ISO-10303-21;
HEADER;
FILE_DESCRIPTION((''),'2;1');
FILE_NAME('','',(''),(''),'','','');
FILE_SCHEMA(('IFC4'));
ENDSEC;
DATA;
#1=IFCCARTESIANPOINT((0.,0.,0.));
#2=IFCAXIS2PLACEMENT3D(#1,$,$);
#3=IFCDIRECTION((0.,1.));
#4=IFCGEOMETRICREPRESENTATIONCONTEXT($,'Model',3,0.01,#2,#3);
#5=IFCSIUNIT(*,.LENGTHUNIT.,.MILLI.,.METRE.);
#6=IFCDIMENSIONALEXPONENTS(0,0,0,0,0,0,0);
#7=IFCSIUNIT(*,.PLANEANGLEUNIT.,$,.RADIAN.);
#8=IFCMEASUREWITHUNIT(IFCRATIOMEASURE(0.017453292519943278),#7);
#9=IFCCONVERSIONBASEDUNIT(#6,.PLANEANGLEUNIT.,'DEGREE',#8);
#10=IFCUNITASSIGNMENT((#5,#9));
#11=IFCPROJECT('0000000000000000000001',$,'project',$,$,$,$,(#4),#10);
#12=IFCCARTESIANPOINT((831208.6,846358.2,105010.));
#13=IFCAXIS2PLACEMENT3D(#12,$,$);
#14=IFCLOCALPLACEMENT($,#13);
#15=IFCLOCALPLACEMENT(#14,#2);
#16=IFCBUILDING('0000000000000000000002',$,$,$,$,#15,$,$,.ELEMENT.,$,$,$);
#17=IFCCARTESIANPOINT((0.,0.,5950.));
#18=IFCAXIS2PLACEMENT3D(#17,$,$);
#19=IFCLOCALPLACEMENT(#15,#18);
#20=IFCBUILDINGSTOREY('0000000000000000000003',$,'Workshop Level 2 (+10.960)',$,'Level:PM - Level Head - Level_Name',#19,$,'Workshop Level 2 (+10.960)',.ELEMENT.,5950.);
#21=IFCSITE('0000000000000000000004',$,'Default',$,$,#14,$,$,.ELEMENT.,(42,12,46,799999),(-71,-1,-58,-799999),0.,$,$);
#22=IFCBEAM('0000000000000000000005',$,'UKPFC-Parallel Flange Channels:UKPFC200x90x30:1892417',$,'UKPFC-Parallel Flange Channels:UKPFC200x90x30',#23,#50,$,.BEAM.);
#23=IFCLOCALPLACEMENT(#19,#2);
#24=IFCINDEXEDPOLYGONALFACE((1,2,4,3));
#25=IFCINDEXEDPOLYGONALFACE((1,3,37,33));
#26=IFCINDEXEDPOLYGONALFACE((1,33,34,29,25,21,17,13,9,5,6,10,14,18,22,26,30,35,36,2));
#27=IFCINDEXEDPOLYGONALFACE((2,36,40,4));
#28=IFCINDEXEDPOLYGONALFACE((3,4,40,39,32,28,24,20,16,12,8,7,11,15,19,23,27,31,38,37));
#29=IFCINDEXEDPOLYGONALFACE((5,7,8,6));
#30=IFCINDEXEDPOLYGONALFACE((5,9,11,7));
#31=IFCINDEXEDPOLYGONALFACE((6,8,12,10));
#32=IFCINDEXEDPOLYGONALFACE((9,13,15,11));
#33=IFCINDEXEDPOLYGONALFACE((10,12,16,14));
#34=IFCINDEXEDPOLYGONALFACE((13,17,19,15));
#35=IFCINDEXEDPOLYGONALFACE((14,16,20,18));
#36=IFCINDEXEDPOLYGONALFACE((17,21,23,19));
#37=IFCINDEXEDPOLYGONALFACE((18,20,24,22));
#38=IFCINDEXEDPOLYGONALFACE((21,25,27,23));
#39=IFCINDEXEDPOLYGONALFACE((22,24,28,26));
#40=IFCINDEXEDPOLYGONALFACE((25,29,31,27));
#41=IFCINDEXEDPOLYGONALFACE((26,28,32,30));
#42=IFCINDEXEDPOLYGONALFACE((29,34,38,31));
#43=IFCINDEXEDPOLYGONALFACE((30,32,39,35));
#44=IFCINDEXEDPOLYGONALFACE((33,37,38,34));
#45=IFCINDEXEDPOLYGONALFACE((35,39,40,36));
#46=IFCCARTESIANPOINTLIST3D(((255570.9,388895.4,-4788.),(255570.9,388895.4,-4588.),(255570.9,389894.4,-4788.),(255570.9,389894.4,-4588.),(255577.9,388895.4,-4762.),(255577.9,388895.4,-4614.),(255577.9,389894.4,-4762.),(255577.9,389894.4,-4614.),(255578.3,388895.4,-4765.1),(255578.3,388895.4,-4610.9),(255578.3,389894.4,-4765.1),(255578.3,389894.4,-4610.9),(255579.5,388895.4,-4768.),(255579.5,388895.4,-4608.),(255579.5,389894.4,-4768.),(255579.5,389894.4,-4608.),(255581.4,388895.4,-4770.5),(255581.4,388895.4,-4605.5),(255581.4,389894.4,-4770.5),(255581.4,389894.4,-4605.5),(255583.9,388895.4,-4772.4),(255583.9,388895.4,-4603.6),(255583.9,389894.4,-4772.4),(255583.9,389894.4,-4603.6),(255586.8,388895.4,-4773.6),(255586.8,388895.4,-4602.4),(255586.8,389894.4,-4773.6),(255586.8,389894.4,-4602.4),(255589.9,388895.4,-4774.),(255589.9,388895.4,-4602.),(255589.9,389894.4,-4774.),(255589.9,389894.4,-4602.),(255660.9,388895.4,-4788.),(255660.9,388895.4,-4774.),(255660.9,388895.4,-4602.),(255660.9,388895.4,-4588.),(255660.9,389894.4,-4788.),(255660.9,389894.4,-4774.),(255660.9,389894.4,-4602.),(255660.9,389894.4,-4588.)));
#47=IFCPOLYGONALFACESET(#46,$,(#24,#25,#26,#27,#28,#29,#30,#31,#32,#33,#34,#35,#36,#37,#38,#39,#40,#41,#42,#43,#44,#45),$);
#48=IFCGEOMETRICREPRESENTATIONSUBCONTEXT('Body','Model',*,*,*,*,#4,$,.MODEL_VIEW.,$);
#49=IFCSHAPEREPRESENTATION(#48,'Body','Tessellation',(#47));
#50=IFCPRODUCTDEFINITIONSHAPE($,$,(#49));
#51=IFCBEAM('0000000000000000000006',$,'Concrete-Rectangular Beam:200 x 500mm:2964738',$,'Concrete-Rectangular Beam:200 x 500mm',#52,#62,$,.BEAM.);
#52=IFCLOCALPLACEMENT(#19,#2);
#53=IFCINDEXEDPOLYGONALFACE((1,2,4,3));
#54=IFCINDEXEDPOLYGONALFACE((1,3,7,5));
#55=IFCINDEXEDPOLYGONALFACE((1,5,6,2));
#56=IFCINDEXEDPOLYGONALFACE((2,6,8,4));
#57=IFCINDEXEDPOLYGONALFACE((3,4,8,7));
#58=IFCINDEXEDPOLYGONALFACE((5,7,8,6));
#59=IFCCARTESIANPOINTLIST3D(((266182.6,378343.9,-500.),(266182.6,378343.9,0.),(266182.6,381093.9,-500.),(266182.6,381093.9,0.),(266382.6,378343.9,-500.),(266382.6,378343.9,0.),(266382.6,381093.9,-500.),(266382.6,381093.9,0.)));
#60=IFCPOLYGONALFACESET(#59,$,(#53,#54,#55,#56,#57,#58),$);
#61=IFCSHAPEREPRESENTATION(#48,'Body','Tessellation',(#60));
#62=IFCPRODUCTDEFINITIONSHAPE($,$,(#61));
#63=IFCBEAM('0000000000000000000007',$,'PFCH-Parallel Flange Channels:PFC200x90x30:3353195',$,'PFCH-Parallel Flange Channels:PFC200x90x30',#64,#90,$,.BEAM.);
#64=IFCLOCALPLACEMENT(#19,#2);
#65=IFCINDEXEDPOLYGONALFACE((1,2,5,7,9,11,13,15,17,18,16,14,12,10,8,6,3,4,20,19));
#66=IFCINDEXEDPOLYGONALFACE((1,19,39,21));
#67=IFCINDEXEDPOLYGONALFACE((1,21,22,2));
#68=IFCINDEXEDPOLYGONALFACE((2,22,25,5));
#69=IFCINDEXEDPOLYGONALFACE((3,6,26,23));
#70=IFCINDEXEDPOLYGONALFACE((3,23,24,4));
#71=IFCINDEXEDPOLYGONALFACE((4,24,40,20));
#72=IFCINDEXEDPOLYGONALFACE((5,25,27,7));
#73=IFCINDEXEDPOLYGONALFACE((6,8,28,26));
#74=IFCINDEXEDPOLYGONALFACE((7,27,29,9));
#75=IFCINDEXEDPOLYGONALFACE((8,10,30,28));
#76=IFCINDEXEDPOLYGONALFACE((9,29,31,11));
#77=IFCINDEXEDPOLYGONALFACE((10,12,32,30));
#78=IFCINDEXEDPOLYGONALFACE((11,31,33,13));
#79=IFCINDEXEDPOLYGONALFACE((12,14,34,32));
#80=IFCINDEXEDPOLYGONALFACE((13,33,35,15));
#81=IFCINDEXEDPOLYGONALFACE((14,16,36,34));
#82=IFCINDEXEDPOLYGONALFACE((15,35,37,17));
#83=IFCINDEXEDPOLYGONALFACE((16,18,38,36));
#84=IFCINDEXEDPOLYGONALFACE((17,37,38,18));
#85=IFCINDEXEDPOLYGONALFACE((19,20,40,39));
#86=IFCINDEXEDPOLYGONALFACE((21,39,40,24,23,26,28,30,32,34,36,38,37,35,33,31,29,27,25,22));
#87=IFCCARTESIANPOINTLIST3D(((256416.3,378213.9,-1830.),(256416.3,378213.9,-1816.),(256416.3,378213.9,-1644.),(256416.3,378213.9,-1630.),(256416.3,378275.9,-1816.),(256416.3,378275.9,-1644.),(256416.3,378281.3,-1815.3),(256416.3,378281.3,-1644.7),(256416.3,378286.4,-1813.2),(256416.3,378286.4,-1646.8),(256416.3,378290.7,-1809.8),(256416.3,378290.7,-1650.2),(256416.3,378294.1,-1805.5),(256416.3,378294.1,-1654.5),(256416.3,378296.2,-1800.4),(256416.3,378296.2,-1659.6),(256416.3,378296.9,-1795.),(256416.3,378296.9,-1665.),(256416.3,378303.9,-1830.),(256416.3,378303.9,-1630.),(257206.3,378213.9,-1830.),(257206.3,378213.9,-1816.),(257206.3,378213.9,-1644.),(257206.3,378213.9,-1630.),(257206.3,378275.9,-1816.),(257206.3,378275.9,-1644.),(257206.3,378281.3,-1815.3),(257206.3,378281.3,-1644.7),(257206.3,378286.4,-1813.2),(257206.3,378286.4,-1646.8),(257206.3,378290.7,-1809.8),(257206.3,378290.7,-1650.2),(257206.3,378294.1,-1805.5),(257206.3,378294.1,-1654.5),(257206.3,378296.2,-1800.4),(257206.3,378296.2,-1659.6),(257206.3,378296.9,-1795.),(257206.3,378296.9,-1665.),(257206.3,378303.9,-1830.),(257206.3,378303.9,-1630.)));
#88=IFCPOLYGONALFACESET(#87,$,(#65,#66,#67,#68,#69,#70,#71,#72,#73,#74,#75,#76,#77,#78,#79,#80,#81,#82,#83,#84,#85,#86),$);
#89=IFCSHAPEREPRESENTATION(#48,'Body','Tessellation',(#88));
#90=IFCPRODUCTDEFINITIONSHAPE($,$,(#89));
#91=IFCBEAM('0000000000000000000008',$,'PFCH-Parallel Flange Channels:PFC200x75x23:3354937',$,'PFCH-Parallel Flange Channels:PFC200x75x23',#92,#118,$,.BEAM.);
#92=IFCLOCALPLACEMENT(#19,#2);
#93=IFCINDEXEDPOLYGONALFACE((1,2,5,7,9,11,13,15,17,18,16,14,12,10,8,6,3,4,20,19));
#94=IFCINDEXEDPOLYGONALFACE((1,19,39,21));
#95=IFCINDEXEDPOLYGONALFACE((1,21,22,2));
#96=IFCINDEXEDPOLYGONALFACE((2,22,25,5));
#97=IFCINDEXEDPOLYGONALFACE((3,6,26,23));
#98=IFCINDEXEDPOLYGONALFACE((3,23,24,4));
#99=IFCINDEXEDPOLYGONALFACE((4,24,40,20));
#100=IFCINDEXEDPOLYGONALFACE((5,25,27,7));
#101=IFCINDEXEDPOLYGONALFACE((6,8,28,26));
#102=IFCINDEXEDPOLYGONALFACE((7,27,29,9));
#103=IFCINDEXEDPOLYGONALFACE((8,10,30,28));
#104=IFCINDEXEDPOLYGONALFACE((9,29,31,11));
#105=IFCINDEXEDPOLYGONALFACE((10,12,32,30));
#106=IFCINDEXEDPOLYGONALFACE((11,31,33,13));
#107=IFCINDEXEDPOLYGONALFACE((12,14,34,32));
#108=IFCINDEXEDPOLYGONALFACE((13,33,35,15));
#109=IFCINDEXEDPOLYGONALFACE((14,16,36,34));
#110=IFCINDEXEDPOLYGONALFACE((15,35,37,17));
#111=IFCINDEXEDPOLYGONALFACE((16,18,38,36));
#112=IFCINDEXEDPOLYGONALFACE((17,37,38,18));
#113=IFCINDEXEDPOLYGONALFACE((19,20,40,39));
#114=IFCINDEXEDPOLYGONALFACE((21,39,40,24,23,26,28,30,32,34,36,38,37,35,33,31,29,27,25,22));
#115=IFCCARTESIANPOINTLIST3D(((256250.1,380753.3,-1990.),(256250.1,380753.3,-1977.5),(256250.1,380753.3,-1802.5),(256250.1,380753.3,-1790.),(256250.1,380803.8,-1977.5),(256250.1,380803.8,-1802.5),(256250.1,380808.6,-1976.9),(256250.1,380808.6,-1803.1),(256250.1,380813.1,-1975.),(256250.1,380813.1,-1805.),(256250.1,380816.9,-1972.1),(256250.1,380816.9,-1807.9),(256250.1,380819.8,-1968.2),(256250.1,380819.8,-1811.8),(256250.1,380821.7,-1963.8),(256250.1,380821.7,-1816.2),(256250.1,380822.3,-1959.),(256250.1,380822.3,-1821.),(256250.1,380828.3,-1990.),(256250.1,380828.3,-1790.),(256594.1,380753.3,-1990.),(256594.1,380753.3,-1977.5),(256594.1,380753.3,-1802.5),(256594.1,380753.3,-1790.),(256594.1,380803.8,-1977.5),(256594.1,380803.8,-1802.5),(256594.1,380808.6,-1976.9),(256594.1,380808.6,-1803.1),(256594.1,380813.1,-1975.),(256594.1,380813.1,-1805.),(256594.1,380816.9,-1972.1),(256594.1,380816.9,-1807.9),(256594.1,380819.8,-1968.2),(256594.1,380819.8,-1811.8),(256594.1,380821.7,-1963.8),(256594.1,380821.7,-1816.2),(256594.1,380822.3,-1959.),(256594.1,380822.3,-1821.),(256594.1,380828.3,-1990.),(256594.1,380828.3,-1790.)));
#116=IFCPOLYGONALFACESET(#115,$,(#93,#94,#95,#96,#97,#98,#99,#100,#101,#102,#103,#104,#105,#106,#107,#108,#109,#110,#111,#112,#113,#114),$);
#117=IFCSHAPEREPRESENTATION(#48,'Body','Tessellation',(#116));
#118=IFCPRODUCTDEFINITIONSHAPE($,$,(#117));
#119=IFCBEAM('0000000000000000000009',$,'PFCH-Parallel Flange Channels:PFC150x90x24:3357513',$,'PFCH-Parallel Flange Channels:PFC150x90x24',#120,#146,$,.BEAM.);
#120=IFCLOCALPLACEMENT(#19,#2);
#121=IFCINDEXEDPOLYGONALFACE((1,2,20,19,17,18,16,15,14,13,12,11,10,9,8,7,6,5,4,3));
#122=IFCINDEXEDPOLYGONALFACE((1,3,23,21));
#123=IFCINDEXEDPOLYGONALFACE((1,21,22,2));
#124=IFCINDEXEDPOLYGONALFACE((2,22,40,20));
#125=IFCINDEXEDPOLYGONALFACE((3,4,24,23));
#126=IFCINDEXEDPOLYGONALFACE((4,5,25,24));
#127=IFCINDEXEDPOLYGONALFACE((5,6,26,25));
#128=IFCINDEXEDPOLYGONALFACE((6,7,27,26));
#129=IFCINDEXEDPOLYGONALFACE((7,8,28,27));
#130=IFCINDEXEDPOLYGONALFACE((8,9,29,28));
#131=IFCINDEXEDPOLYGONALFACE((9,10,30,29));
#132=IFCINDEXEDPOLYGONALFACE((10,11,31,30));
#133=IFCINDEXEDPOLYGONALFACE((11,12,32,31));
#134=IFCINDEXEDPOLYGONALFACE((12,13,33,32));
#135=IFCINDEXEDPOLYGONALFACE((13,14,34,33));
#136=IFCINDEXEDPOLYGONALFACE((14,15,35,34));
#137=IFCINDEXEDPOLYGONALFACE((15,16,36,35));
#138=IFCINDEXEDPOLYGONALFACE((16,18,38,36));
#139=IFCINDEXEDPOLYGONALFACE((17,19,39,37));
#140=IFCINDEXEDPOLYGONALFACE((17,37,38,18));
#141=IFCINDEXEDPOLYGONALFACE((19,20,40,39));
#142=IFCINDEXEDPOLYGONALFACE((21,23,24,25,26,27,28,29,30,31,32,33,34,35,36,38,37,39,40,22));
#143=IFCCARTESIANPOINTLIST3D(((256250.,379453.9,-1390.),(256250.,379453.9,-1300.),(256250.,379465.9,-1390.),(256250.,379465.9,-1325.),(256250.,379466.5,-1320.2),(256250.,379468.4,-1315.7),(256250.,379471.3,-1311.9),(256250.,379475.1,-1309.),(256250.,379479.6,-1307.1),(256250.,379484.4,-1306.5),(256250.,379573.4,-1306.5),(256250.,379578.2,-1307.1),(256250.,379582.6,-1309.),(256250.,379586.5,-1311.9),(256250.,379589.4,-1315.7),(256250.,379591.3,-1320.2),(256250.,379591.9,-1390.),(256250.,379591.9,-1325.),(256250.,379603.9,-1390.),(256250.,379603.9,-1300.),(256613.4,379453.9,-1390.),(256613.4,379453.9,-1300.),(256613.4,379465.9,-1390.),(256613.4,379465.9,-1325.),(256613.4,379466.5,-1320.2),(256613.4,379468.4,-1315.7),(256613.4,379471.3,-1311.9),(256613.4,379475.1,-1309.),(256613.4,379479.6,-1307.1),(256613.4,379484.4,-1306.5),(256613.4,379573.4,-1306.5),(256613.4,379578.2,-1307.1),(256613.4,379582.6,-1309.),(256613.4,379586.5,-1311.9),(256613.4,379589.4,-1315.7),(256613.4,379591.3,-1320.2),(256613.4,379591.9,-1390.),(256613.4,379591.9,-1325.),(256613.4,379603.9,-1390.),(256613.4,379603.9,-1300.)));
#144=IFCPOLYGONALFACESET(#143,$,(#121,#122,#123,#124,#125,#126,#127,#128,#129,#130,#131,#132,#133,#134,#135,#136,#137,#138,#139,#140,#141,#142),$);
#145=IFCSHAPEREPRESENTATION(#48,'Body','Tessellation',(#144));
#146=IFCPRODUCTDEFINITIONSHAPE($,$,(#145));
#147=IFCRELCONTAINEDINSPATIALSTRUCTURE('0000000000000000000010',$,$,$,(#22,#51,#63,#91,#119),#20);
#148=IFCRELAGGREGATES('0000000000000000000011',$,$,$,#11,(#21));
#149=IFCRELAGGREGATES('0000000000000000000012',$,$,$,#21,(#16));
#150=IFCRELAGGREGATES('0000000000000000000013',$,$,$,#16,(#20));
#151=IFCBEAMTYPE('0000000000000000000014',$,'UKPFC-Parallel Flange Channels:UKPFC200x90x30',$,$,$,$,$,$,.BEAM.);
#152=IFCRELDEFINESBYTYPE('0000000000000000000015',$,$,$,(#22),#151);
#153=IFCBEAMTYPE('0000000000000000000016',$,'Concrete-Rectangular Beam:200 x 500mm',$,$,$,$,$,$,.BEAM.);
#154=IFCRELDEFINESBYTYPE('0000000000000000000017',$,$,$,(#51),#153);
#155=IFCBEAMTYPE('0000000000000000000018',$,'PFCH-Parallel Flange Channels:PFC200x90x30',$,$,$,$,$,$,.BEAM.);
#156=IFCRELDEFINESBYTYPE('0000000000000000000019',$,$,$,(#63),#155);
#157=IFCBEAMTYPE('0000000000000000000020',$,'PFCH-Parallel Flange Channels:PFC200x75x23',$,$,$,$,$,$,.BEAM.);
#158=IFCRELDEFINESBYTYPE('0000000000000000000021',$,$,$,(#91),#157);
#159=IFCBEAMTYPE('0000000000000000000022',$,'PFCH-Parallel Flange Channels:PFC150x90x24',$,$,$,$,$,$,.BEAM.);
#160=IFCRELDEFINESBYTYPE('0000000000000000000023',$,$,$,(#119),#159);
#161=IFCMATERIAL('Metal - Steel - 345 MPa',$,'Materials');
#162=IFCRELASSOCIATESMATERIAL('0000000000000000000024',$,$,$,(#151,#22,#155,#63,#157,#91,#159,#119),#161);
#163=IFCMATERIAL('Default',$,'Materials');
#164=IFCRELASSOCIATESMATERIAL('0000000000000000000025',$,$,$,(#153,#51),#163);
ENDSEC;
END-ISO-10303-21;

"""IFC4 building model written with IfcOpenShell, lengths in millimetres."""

from ifc_helpers import new_model, entity, si_unit, converted_unit, direction, frame, origin, place, context, subcontext, project, spatial, line, arc, indexed_curve, outline, extrude, source, transform, mapped, material, type_object, type_shapes, element, save


model = new_model("IFC4")

# Units and contexts
model_context = context("Model", 3, precision=0.01, world=origin(), true_north=direction((0.0, 1.0)))
body_context = subcontext(model_context, "Body", "Model", "MODEL_VIEW")
ifc_project = project(units=[si_unit("LENGTHUNIT", "METRE", prefix="MILLI"), converted_unit("PLANEANGLEUNIT", "DEGREE", entity("IfcRatioMeasure", 0.017453292519943278), si_unit("PLANEANGLEUNIT", "RADIAN"), dimensions=[0, 0, 0, 0, 0, 0, 0])], contexts=[model_context])

# Site, building, storey
site_placement = place(None, frame((831208.6, 846358.2, 105010.0)))
site = spatial("IfcSite", under=ifc_project, at=site_placement, Name="Default", CompositionType="ELEMENT", RefLatitude=(42, 12, 46, 799999), RefLongitude=(-71, -1, -58, -799999), RefElevation=0.0)
building_placement = place(site_placement, origin())
building = spatial("IfcBuilding", under=site, at=building_placement, CompositionType="ELEMENT")
storey_placement = place(building_placement, frame((0.0, 0.0, 5950.0)))
storey = spatial("IfcBuildingStorey", under=building, at=storey_placement, Name="Workshop Level 2 (+10.960)", ObjectType="Level:PM - Level Head - Level_Name", LongName="Workshop Level 2 (+10.960)", CompositionType="ELEMENT", Elevation=5950.0)

# Beams
ifc_material_1 = material(Name="Metal - Steel - 345 MPa", Category="Materials")
beam_type_1 = type_object("IfcBeamType", Name="UKPFC-Parallel Flange Channels:UKPFC200x90x30", PredefinedType="BEAM", material=ifc_material_1)
shared_shape_1 = source(origin(), body_context, "Body", "SweptSolid", [
    extrude(outline(indexed_curve([(-100.0, -48.8), (-86.0, -48.8), (-86.0, 22.2), (-82.5, 30.7), (-74.0, 34.2), (74.0, 34.2), (82.5, 30.7), (86.0, 22.2), (86.0, -48.8), (100.0, -48.8), (100.0, 41.2), (-100.0, 41.2)], segments=[line(1, 2, 3), arc(3, 4, 5), line(5, 6), arc(6, 7, 8), line(8, 9, 10, 11, 12, 1)], self_intersect=False)), frame((-534.0, -10.0, 0.0), z_axis=(1.0, 0.0, 0.0), x_axis=(0.0, 0.0, -1.0)), (0.0, 0.0, 1.0), 999.0),
])
type_shapes(beam_type_1, [shared_shape_1])
beam_1_placement = place(storey_placement, frame((255602.1, 389429.4, -4688.0), z_axis=(0.0, 0.0, 1.0), x_axis=(0.0, 1.0, 0.0)))
element("IfcBeam", 1, at=beam_1_placement, inside=storey, type_object=beam_type_1, material=ifc_material_1, Name="UKPFC-Parallel Flange Channels:UKPFC200x90x30:1892417", ObjectType="UKPFC-Parallel Flange Channels:UKPFC200x90x30", PredefinedType="BEAM", context=body_context, shape_type="MappedRepresentation", body=[
    mapped(shared_shape_1, transform((0.0, 0.0, 0.0), scale=1.0)),
])
ifc_material_2 = material(Name="Default", Category="Materials")
beam_type_2 = type_object("IfcBeamType", Name="Concrete-Rectangular Beam:200 x 500mm", PredefinedType="BEAM", material=ifc_material_2)
shared_shape_2 = source(origin(), body_context, "Body", "SweptSolid", [
    extrude(outline(indexed_curve([(-100.0, -250.0), (100.0, -250.0), (100.0, 250.0), (-100.0, 250.0), (-100.0, -250.0)], self_intersect=False)), frame((266282.6, 381093.9, 5700.0), z_axis=(0.0, -1.0, 0.0), x_axis=(-1.0, 0.0, 0.0)), (0.0, 0.0, 1.0), 2750.0),
])
type_shapes(beam_type_2, [shared_shape_2])
beam_2_placement = place(storey_placement, frame((0.0, 0.0, -5950.0)))
element("IfcBeam", 2, at=beam_2_placement, inside=storey, type_object=beam_type_2, material=ifc_material_2, Name="Concrete-Rectangular Beam:200 x 500mm:2964738", ObjectType="Concrete-Rectangular Beam:200 x 500mm", PredefinedType="BEAM", context=body_context, shape_type="MappedRepresentation", body=[
    mapped(shared_shape_2, transform((0.0, 0.0, 0.0), scale=1.0)),
])
beam_type_3 = type_object("IfcBeamType", Name="PFCH-Parallel Flange Channels:PFC200x90x30", PredefinedType="BEAM", material=ifc_material_1)
shared_shape_3 = source(origin(), body_context, "Body", "SweptSolid", [
    extrude(outline(indexed_curve([(-100.0, -47.0), (-86.0, -47.0), (-86.0, 15.0), (-79.8, 29.8), (-65.0, 36.0), (65.0, 36.0), (79.8, 29.8), (86.0, 15.0), (86.0, -47.0), (100.0, -47.0), (100.0, 43.0), (-100.0, 43.0)], segments=[line(1, 2, 3), arc(3, 4, 5), line(5, 6), arc(6, 7, 8), line(8, 9, 10, 11, 12, 1)], self_intersect=False)), frame((-395.0, -12.0, 0.0), z_axis=(1.0, 0.0, 0.0), x_axis=(0.0, 0.0, -1.0)), (0.0, 0.0, 1.0), 790.0),
])
type_shapes(beam_type_3, [shared_shape_3])
beam_3_placement = place(storey_placement, frame((256811.3, 378272.9, -1730.0)))
element("IfcBeam", 3, at=beam_3_placement, inside=storey, type_object=beam_type_3, material=ifc_material_1, Name="PFCH-Parallel Flange Channels:PFC200x90x30:3353195", ObjectType="PFCH-Parallel Flange Channels:PFC200x90x30", PredefinedType="BEAM", context=body_context, shape_type="MappedRepresentation", body=[
    mapped(shared_shape_3, transform((0.0, 0.0, 0.0), scale=1.0)),
])
beam_type_4 = type_object("IfcBeamType", Name="PFCH-Parallel Flange Channels:PFC200x75x23", PredefinedType="BEAM", material=ifc_material_1)
shared_shape_4 = source(origin(), body_context, "Body", "SweptSolid", [
    extrude(outline(indexed_curve([(-100.0, -38.9), (-87.5, -38.9), (-87.5, 11.6), (-82.1, 24.7), (-69.0, 30.1), (69.0, 30.1), (82.1, 24.7), (87.5, 11.6), (87.5, -38.9), (100.0, -38.9), (100.0, 36.1), (-100.0, 36.1)], segments=[line(1, 2, 3), arc(3, 4, 5), line(5, 6), arc(6, 7, 8), line(8, 9, 10, 11, 12, 1)], self_intersect=False)), frame((-244.0, -11.1, 0.0), z_axis=(1.0, 0.0, 0.0), x_axis=(0.0, 0.0, -1.0)), (0.0, 0.0, 1.0), 344.0),
])
type_shapes(beam_type_4, [shared_shape_4])
beam_4_placement = place(storey_placement, frame((256494.1, 380803.3, -1890.0)))
element("IfcBeam", 4, at=beam_4_placement, inside=storey, type_object=beam_type_4, material=ifc_material_1, Name="PFCH-Parallel Flange Channels:PFC200x75x23:3354937", ObjectType="PFCH-Parallel Flange Channels:PFC200x75x23", PredefinedType="BEAM", context=body_context, shape_type="MappedRepresentation", body=[
    mapped(shared_shape_4, transform((0.0, 0.0, 0.0), scale=1.0)),
])
beam_type_5 = type_object("IfcBeamType", Name="PFCH-Parallel Flange Channels:PFC150x90x24", PredefinedType="BEAM", material=ifc_material_1)
shared_shape_5 = source(origin(), body_context, "Body", "SweptSolid", [
    extrude(outline(indexed_curve([(-75.0, -42.3), (75.0, -42.3), (75.0, 47.7), (63.0, 47.7), (63.0, -17.3), (57.6, -30.4), (44.5, -35.8), (-44.5, -35.8), (-57.6, -30.4), (-63.0, -17.3), (-63.0, 47.7), (-75.0, 47.7)], segments=[line(1, 2, 3, 4, 5), arc(5, 6, 7), line(7, 8), arc(8, 9, 10), line(10, 11, 12, 1)], self_intersect=False)), frame((-181.5, 9.3, 0.0), z_axis=(1.0, 0.0, 0.0), x_axis=(0.0, 0.0, -1.0)), (0.0, 0.0, 1.0), 363.4),
])
type_shapes(beam_type_5, [shared_shape_5])
beam_5_placement = place(storey_placement, frame((256431.5, 379528.9, -1333.0), z_axis=(0.0, 1.0, 0.0), x_axis=(1.0, 0.0, 0.0)))
element("IfcBeam", 5, at=beam_5_placement, inside=storey, type_object=beam_type_5, material=ifc_material_1, Name="PFCH-Parallel Flange Channels:PFC150x90x24:3357513", ObjectType="PFCH-Parallel Flange Channels:PFC150x90x24", PredefinedType="BEAM", context=body_context, shape_type="MappedRepresentation", body=[
    mapped(shared_shape_5, transform((0.0, 0.0, 0.0), scale=1.0)),
])

save(model, "model.ifc")
